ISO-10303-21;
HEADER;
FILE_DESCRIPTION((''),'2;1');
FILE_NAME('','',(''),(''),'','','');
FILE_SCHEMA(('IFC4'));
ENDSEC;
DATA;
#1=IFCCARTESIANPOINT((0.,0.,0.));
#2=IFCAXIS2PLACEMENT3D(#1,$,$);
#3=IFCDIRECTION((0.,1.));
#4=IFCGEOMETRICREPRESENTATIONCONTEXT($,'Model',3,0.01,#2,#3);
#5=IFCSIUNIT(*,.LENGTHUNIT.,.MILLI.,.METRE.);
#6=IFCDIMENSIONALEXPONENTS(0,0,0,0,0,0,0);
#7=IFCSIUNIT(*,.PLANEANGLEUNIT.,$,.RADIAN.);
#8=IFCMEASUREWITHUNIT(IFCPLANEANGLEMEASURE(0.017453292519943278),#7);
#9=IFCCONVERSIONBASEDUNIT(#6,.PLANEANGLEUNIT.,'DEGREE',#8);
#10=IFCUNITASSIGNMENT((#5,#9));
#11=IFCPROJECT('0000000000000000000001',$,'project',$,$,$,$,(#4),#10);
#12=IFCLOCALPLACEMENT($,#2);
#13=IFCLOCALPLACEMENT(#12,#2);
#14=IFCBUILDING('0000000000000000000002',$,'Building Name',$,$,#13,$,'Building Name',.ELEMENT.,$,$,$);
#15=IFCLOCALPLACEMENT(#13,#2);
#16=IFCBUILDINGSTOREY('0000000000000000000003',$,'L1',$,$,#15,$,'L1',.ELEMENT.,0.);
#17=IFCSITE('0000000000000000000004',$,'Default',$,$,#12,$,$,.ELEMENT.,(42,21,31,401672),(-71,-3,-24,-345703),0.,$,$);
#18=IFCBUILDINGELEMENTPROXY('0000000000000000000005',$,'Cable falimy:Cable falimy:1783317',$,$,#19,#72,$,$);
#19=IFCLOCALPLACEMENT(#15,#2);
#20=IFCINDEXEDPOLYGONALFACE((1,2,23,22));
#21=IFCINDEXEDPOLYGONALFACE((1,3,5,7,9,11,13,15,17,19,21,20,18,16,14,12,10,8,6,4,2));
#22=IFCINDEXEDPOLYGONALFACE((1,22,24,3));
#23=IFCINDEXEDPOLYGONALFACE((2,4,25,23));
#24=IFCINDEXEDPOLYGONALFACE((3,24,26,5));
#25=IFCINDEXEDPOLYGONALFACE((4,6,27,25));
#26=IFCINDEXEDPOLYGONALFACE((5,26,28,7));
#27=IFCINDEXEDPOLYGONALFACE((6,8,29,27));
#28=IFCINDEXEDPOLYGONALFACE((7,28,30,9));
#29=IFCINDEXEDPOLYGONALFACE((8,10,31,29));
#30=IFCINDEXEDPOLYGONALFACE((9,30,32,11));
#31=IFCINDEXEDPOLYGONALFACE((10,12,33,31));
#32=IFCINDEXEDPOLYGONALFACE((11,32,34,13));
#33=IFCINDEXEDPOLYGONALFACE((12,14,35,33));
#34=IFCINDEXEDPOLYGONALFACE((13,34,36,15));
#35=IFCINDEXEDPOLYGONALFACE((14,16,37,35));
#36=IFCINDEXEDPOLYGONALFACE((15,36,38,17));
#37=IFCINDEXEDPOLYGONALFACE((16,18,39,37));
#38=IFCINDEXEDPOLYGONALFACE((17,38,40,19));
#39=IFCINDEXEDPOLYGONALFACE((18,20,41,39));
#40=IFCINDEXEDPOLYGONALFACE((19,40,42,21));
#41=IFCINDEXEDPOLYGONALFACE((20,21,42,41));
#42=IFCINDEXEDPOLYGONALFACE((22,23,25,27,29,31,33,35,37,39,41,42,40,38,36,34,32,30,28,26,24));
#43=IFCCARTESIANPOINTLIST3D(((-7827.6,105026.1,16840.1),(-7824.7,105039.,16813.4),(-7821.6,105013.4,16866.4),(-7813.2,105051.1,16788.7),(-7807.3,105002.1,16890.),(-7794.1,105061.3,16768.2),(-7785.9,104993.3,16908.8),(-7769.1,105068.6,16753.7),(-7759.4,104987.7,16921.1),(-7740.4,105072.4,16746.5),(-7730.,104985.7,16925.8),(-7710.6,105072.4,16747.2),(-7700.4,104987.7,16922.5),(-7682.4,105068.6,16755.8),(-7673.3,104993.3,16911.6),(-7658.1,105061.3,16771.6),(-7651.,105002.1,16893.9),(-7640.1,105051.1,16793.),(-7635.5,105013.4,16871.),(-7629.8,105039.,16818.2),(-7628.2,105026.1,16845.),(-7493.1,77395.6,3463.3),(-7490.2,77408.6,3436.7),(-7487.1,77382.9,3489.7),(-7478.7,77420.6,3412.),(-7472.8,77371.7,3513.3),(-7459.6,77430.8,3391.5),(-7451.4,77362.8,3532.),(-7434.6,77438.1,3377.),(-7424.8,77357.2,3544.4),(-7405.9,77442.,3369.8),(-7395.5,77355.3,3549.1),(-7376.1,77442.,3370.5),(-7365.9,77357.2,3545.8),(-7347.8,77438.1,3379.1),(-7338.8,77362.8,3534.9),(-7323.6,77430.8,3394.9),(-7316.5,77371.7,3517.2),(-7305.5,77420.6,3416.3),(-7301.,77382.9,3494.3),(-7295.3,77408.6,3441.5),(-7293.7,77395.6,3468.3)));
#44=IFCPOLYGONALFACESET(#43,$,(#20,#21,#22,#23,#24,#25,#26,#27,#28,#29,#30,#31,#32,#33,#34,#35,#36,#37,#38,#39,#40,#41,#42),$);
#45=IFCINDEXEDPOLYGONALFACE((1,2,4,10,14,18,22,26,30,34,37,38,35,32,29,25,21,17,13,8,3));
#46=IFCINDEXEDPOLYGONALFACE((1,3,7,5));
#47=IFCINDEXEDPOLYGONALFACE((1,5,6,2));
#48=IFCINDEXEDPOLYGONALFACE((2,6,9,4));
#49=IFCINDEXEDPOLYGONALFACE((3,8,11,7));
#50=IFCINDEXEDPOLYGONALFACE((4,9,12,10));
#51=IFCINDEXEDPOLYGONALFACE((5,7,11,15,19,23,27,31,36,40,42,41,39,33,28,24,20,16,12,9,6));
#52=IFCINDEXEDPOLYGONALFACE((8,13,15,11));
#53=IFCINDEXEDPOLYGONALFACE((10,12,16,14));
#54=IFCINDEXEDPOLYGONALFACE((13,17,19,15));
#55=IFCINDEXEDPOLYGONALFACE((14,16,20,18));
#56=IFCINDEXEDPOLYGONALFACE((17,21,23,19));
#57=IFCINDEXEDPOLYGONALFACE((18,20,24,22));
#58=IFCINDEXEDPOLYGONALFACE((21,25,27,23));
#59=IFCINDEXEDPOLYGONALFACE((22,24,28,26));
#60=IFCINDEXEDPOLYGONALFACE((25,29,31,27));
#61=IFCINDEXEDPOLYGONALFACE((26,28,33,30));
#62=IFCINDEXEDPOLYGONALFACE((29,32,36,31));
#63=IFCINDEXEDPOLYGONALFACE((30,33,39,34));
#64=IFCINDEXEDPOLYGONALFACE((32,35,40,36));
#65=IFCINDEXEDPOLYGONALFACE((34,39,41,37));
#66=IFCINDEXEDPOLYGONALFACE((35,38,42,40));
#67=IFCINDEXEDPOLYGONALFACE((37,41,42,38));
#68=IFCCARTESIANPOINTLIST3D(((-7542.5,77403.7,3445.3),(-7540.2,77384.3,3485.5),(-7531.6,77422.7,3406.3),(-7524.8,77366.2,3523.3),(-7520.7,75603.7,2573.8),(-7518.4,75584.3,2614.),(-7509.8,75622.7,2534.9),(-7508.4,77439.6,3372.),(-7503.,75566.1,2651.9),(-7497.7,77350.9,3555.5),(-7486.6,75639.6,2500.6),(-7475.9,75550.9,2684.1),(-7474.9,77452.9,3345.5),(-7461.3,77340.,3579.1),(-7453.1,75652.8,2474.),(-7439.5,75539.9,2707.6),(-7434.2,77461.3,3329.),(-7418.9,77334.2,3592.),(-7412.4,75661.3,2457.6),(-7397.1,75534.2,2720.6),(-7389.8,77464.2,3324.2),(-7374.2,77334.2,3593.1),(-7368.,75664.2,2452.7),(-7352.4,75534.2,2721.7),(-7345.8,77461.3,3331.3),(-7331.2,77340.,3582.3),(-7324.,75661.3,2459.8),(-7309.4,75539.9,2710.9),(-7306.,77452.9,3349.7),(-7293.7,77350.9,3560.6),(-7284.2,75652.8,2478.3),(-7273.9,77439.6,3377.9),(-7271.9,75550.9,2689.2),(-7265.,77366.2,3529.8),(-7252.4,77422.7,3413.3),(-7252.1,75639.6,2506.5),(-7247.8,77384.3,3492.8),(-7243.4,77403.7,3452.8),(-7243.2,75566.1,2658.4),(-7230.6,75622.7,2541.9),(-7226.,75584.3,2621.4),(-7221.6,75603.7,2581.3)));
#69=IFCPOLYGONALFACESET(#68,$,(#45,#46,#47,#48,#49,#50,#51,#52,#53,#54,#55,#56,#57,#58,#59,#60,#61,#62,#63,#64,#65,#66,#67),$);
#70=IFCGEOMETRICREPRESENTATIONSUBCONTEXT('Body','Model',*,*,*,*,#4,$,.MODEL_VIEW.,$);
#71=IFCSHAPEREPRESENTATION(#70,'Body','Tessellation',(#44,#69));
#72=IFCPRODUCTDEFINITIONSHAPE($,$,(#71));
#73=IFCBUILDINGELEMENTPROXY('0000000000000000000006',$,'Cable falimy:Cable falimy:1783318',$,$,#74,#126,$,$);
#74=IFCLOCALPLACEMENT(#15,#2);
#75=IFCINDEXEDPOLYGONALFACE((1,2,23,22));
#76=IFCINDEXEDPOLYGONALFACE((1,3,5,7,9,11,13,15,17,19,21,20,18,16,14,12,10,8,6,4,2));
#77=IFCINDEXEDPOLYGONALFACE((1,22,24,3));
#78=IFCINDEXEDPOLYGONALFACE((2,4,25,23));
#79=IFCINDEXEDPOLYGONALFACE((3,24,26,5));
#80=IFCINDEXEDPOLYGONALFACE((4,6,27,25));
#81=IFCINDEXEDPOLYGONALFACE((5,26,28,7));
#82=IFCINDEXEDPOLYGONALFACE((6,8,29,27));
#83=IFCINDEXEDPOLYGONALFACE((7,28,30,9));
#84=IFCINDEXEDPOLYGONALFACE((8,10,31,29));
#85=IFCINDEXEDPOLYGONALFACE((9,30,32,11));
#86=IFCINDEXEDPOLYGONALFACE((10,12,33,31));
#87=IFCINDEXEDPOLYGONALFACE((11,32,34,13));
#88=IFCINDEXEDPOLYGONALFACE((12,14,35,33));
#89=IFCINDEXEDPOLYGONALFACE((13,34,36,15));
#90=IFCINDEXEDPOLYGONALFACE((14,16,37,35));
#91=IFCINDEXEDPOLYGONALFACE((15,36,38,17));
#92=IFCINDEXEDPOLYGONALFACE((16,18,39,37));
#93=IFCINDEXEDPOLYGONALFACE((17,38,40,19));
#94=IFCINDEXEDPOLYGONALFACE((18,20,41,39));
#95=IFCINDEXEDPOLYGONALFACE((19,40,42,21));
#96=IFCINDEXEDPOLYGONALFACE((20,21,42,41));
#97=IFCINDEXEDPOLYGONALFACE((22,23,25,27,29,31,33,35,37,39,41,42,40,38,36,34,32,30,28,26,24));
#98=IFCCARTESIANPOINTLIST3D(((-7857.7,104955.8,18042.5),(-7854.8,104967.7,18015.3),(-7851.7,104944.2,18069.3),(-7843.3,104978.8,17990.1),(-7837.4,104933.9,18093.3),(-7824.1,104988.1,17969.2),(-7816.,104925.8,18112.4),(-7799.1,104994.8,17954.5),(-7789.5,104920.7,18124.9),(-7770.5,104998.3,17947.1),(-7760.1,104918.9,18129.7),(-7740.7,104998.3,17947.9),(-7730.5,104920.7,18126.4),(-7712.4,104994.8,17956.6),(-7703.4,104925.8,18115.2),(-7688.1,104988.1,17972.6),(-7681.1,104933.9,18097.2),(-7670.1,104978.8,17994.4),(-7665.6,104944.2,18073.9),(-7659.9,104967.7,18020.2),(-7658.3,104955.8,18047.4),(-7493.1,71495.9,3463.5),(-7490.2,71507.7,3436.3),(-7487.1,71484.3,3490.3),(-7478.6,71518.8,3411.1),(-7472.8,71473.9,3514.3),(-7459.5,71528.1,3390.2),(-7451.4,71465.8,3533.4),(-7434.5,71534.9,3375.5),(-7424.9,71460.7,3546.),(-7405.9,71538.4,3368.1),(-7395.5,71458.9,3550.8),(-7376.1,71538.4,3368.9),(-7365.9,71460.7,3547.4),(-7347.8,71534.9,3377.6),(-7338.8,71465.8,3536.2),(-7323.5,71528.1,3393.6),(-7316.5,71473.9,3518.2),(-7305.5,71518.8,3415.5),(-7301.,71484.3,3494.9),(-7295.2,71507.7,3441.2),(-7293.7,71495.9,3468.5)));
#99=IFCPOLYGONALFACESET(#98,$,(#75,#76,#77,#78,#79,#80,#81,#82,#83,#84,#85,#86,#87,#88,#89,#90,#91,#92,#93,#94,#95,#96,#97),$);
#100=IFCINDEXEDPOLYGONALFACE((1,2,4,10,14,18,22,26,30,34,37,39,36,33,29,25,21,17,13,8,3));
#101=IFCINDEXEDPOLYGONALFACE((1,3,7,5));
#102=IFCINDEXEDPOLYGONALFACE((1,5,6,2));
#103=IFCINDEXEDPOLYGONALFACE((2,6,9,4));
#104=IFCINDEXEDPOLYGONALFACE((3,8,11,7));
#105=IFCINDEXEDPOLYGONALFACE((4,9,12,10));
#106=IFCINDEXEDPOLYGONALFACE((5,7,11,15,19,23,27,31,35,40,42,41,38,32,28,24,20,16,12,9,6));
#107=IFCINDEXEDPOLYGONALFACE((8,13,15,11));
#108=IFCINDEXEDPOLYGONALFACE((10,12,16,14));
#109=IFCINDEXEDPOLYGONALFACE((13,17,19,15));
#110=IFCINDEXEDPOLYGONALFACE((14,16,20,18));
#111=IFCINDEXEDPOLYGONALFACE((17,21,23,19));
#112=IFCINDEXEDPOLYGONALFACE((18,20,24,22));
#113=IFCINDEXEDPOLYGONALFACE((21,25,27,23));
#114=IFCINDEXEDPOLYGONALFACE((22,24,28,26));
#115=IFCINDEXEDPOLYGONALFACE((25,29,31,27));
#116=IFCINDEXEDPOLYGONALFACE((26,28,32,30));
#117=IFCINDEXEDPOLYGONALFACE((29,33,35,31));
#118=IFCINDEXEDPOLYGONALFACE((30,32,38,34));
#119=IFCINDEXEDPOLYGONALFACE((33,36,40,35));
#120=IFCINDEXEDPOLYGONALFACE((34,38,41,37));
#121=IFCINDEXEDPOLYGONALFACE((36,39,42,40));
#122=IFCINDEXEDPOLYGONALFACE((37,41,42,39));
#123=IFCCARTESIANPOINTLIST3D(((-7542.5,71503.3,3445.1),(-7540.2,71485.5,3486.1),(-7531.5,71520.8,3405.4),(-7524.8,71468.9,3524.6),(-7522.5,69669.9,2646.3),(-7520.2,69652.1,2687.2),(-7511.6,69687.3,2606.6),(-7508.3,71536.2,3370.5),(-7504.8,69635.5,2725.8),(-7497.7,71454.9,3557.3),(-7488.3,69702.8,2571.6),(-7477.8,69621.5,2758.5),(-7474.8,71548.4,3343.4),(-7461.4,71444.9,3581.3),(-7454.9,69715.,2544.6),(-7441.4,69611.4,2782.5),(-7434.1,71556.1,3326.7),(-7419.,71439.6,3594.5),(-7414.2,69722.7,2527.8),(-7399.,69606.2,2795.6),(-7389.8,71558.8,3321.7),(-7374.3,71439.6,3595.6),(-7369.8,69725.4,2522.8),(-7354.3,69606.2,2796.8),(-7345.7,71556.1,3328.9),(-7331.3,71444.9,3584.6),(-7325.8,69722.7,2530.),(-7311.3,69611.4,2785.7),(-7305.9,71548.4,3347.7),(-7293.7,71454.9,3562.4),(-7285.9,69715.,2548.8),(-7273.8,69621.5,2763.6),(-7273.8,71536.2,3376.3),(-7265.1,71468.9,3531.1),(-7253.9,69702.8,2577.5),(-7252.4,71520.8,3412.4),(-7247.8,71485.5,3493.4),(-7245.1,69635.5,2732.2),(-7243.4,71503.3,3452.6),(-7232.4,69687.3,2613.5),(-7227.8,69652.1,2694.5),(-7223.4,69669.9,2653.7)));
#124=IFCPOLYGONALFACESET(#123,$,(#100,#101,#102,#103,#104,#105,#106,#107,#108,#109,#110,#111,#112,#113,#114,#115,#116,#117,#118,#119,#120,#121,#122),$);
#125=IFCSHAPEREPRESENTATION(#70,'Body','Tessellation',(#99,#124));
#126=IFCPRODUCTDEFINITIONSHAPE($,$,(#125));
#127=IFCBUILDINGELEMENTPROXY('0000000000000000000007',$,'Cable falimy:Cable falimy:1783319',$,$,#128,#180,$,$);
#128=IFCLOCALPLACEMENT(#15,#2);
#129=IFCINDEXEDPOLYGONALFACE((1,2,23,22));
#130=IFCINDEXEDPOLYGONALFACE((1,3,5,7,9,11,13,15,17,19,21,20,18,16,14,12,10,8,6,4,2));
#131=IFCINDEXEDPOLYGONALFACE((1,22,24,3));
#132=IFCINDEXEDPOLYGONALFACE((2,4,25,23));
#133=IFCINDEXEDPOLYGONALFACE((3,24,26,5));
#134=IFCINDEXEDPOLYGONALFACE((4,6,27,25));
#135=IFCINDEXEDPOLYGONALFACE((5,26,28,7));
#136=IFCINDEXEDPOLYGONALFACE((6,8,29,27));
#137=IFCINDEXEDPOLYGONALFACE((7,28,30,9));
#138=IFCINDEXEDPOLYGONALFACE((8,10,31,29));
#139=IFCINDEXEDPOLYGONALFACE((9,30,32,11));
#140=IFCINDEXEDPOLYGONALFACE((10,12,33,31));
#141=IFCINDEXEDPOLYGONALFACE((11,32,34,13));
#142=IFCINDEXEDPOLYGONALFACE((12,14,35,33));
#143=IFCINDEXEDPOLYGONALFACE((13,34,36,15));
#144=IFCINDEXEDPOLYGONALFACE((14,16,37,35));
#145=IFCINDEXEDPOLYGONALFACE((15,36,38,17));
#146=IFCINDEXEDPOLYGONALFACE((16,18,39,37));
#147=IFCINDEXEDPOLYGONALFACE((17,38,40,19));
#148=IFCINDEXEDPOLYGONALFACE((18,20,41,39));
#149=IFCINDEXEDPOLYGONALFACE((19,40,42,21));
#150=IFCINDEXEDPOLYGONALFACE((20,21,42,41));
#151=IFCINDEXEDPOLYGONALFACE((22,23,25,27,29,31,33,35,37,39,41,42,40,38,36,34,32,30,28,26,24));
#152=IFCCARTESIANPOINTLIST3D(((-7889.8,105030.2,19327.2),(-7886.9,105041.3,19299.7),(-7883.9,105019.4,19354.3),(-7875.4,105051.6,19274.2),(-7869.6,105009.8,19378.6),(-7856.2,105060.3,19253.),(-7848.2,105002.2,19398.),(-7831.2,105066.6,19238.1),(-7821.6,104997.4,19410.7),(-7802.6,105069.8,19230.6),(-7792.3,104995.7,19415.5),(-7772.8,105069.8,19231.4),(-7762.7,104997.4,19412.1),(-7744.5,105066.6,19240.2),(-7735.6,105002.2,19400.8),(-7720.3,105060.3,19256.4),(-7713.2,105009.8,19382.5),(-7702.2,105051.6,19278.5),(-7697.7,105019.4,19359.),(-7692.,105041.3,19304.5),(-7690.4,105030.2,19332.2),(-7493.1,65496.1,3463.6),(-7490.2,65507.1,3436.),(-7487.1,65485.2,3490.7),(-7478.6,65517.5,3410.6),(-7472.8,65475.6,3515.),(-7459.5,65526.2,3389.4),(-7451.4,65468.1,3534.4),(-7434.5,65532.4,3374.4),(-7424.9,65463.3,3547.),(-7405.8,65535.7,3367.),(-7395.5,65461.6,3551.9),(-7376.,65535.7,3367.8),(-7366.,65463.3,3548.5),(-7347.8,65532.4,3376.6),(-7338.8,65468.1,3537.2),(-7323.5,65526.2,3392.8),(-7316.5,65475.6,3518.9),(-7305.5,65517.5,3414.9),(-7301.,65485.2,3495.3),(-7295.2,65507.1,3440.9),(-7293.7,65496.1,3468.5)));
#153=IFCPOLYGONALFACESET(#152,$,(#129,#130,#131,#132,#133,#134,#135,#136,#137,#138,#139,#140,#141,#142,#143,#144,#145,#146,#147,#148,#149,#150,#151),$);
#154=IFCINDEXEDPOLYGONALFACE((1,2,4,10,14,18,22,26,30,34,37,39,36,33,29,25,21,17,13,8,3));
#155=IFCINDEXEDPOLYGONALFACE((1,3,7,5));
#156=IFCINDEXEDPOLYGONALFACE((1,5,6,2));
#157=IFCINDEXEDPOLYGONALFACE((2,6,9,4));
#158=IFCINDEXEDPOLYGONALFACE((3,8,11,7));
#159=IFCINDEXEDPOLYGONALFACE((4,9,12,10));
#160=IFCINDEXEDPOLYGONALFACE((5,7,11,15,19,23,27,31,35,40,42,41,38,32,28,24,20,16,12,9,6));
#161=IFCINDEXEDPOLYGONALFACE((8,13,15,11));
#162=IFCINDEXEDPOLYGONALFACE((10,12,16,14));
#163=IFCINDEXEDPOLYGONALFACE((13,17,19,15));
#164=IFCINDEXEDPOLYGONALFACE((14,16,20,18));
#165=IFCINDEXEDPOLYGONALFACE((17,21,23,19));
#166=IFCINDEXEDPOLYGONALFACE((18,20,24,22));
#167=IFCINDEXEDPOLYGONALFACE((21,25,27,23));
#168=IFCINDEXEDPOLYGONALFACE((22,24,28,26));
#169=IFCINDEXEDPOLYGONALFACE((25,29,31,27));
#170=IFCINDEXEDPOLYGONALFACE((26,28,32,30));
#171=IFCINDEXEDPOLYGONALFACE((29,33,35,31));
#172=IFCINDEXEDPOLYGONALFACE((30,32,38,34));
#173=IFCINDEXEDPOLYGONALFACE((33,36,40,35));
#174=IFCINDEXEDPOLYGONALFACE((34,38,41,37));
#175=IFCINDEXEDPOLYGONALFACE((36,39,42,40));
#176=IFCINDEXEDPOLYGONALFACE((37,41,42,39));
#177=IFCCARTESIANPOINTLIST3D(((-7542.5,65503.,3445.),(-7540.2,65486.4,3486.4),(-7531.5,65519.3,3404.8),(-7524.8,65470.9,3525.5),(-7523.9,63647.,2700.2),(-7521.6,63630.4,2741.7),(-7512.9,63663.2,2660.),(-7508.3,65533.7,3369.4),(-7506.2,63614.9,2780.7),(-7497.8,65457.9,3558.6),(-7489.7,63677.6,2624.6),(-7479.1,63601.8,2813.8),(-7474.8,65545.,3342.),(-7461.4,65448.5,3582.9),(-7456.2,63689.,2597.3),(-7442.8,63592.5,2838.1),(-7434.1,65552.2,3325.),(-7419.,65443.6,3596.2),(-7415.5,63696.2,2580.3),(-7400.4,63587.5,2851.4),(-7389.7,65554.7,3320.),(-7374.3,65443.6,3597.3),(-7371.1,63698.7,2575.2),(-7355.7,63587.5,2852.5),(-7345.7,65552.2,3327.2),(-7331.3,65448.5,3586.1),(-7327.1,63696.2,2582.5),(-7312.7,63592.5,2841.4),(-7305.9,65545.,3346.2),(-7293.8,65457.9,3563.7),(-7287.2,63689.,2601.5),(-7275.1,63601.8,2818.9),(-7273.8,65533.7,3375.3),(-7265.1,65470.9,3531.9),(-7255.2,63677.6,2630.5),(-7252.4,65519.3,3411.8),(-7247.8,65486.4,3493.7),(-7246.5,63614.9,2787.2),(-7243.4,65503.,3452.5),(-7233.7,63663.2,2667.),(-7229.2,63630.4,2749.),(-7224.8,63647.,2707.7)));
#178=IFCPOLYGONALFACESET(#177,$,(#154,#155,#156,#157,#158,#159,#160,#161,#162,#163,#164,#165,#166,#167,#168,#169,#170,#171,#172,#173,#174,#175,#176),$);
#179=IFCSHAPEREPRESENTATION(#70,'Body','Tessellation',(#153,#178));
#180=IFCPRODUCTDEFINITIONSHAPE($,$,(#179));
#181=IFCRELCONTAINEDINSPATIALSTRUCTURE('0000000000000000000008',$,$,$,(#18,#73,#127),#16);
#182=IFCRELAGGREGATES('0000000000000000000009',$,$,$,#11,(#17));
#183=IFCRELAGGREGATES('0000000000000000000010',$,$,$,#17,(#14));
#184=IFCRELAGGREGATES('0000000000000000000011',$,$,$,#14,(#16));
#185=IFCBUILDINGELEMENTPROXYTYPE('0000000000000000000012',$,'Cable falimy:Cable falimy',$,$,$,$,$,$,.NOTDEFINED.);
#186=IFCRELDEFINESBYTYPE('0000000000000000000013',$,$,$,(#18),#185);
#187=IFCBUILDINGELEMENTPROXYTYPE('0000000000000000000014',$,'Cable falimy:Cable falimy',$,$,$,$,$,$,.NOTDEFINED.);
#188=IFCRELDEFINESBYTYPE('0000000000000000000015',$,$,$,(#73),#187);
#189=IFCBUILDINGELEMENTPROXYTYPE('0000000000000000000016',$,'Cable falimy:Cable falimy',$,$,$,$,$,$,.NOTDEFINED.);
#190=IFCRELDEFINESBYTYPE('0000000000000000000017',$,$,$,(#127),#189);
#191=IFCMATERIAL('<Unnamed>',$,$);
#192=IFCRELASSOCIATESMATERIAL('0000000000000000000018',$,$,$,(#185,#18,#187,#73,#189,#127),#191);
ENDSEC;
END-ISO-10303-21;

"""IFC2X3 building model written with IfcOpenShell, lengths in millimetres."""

from ifc_helpers import new_model, entity, si_unit, converted_unit, direction, frame, frame_2d, origin, place, context, subcontext, project, spatial, circle, extrude, source, transform, mapped, material, type_object, type_shapes, element, save


model = new_model("IFC2X3")

# Units and contexts
model_context = context("Model", 3, precision=0.01, world=origin(), true_north=direction((0.0, 1.0)))
body_context = subcontext(model_context, "Body", "Model", "MODEL_VIEW")
ifc_project = project(units=[si_unit("LENGTHUNIT", "METRE", prefix="MILLI"), converted_unit("PLANEANGLEUNIT", "DEGREE", entity("IfcPlaneAngleMeasure", 0.017453292519943278), si_unit("PLANEANGLEUNIT", "RADIAN"), dimensions=[0, 0, 0, 0, 0, 0, 0])], contexts=[model_context])

# Site, building, storey
site_placement = place(None, origin())
site = spatial("IfcSite", under=ifc_project, at=site_placement, Name="Default", CompositionType="ELEMENT", RefLatitude=(42, 21, 31, 401672), RefLongitude=(-71, -3, -24, -345703), RefElevation=0.0)
building_placement = place(site_placement, origin())
building = spatial("IfcBuilding", under=site, at=building_placement, Name="Building Name", LongName="Building Name", CompositionType="ELEMENT")
storey_placement = place(building_placement, origin())
storey = spatial("IfcBuildingStorey", under=building, at=storey_placement, Name="L1", LongName="L1", CompositionType="ELEMENT", Elevation=0.0)

# Shared definitions
ifc_material = material(Name="<Unnamed>")

# Building element proxies
building_element_proxy_type_1 = type_object("IfcBuildingElementProxyType", Name="Cable falimy:Cable falimy", PredefinedType="NOTDEFINED", material=ifc_material)
shared_shape_1 = source(origin(), body_context, "Body", "SweptSolid", [
    extrude(circle(Radius=100.0, at=frame_2d((0.0, 0.0), x_axis=(1.0, 0.0))), frame((0.0, 0.0, 0.0), z_axis=(0.900015, 0.0, 0.43586), x_axis=(-0.43586, 0.0, 0.900015)), (0.0, 0.0, 1.0), 30700.0),
    extrude(circle(Radius=150.0, at=frame_2d((0.0, 0.0), x_axis=(1.0, 0.0))), frame((-1800.0, 0.0, -871.7), z_axis=(0.900015, 0.0, 0.43586), x_axis=(0.43586, 0.0, -0.900015)), (0.0, 0.0, 1.0), 2000.0),
])
type_shapes(building_element_proxy_type_1, [shared_shape_1])
proxy_1_placement = place(storey_placement, frame((-7393.2, 77398.9, 3459.1), z_axis=(-0.025001, 0.0, 0.999687), x_axis=(0.0, 1.0, 0.0)))
element("IfcBuildingElementProxy", 1, at=proxy_1_placement, inside=storey, type_object=building_element_proxy_type_1, material=ifc_material, Name="Cable falimy:Cable falimy:1783317", context=body_context, shape_type="MappedRepresentation", body=[
    mapped(shared_shape_1, transform((0.0, 0.0, 0.0), scale=1.0)),
])
building_element_proxy_type_2 = type_object("IfcBuildingElementProxyType", Name="Cable falimy:Cable falimy", PredefinedType="NOTDEFINED", material=ifc_material)
shared_shape_2 = source(origin(), body_context, "Body", "SweptSolid", [
    extrude(circle(Radius=100.0, at=frame_2d((0.0, 0.0), x_axis=(1.0, 0.0))), frame((0.0, 0.0, 0.0), z_axis=(0.916712, 0.0, 0.399549), x_axis=(-0.399549, 0.0, 0.916712)), (0.0, 0.0, 1.0), 36500.0),
    extrude(circle(Radius=150.0, at=frame_2d((0.0, 0.0), x_axis=(1.0, 0.0))), frame((-1833.4, 0.0, -799.1), z_axis=(0.916712, 0.0, 0.399549), x_axis=(0.399549, 0.0, -0.916712)), (0.0, 0.0, 1.0), 2000.0),
])
type_shapes(building_element_proxy_type_2, [shared_shape_2])
proxy_2_placement = place(storey_placement, frame((-7393.2, 71498.9, 3459.1), z_axis=(-0.025001, 0.0, 0.999687), x_axis=(0.0, 1.0, 0.0)))
element("IfcBuildingElementProxy", 2, at=proxy_2_placement, inside=storey, type_object=building_element_proxy_type_2, material=ifc_material, Name="Cable falimy:Cable falimy:1783318", context=body_context, shape_type="MappedRepresentation", body=[
    mapped(shared_shape_2, transform((0.0, 0.0, 0.0), scale=1.0)),
])
building_element_proxy_type_3 = type_object("IfcBuildingElementProxyType", Name="Cable falimy:Cable falimy", PredefinedType="NOTDEFINED", material=ifc_material)
shared_shape_3 = source(origin(), body_context, "Body", "SweptSolid", [
    extrude(circle(Radius=100.0, at=frame_2d((0.0, 0.0), x_axis=(1.0, 0.0))), frame((0.0, 0.0, 0.0), z_axis=(0.928031, 0.0, 0.372502), x_axis=(-0.372502, 0.0, 0.928031)), (0.0, 0.0, 1.0), 42600.0),
    extrude(circle(Radius=150.0, at=frame_2d((0.0, 0.0), x_axis=(1.0, 0.0))), frame((-1856.1, 0.0, -745.0), z_axis=(0.928031, 0.0, 0.372502), x_axis=(0.372502, 0.0, -0.928031)), (0.0, 0.0, 1.0), 2000.0),
])
type_shapes(building_element_proxy_type_3, [shared_shape_3])
proxy_3_placement = place(storey_placement, frame((-7393.2, 65498.9, 3459.1), z_axis=(-0.025001, 0.0, 0.999687), x_axis=(0.0, 1.0, 0.0)))
element("IfcBuildingElementProxy", 3, at=proxy_3_placement, inside=storey, type_object=building_element_proxy_type_3, material=ifc_material, Name="Cable falimy:Cable falimy:1783319", context=body_context, shape_type="MappedRepresentation", body=[
    mapped(shared_shape_3, transform((0.0, 0.0, 0.0), scale=1.0)),
])

save(model, "model.ifc")
